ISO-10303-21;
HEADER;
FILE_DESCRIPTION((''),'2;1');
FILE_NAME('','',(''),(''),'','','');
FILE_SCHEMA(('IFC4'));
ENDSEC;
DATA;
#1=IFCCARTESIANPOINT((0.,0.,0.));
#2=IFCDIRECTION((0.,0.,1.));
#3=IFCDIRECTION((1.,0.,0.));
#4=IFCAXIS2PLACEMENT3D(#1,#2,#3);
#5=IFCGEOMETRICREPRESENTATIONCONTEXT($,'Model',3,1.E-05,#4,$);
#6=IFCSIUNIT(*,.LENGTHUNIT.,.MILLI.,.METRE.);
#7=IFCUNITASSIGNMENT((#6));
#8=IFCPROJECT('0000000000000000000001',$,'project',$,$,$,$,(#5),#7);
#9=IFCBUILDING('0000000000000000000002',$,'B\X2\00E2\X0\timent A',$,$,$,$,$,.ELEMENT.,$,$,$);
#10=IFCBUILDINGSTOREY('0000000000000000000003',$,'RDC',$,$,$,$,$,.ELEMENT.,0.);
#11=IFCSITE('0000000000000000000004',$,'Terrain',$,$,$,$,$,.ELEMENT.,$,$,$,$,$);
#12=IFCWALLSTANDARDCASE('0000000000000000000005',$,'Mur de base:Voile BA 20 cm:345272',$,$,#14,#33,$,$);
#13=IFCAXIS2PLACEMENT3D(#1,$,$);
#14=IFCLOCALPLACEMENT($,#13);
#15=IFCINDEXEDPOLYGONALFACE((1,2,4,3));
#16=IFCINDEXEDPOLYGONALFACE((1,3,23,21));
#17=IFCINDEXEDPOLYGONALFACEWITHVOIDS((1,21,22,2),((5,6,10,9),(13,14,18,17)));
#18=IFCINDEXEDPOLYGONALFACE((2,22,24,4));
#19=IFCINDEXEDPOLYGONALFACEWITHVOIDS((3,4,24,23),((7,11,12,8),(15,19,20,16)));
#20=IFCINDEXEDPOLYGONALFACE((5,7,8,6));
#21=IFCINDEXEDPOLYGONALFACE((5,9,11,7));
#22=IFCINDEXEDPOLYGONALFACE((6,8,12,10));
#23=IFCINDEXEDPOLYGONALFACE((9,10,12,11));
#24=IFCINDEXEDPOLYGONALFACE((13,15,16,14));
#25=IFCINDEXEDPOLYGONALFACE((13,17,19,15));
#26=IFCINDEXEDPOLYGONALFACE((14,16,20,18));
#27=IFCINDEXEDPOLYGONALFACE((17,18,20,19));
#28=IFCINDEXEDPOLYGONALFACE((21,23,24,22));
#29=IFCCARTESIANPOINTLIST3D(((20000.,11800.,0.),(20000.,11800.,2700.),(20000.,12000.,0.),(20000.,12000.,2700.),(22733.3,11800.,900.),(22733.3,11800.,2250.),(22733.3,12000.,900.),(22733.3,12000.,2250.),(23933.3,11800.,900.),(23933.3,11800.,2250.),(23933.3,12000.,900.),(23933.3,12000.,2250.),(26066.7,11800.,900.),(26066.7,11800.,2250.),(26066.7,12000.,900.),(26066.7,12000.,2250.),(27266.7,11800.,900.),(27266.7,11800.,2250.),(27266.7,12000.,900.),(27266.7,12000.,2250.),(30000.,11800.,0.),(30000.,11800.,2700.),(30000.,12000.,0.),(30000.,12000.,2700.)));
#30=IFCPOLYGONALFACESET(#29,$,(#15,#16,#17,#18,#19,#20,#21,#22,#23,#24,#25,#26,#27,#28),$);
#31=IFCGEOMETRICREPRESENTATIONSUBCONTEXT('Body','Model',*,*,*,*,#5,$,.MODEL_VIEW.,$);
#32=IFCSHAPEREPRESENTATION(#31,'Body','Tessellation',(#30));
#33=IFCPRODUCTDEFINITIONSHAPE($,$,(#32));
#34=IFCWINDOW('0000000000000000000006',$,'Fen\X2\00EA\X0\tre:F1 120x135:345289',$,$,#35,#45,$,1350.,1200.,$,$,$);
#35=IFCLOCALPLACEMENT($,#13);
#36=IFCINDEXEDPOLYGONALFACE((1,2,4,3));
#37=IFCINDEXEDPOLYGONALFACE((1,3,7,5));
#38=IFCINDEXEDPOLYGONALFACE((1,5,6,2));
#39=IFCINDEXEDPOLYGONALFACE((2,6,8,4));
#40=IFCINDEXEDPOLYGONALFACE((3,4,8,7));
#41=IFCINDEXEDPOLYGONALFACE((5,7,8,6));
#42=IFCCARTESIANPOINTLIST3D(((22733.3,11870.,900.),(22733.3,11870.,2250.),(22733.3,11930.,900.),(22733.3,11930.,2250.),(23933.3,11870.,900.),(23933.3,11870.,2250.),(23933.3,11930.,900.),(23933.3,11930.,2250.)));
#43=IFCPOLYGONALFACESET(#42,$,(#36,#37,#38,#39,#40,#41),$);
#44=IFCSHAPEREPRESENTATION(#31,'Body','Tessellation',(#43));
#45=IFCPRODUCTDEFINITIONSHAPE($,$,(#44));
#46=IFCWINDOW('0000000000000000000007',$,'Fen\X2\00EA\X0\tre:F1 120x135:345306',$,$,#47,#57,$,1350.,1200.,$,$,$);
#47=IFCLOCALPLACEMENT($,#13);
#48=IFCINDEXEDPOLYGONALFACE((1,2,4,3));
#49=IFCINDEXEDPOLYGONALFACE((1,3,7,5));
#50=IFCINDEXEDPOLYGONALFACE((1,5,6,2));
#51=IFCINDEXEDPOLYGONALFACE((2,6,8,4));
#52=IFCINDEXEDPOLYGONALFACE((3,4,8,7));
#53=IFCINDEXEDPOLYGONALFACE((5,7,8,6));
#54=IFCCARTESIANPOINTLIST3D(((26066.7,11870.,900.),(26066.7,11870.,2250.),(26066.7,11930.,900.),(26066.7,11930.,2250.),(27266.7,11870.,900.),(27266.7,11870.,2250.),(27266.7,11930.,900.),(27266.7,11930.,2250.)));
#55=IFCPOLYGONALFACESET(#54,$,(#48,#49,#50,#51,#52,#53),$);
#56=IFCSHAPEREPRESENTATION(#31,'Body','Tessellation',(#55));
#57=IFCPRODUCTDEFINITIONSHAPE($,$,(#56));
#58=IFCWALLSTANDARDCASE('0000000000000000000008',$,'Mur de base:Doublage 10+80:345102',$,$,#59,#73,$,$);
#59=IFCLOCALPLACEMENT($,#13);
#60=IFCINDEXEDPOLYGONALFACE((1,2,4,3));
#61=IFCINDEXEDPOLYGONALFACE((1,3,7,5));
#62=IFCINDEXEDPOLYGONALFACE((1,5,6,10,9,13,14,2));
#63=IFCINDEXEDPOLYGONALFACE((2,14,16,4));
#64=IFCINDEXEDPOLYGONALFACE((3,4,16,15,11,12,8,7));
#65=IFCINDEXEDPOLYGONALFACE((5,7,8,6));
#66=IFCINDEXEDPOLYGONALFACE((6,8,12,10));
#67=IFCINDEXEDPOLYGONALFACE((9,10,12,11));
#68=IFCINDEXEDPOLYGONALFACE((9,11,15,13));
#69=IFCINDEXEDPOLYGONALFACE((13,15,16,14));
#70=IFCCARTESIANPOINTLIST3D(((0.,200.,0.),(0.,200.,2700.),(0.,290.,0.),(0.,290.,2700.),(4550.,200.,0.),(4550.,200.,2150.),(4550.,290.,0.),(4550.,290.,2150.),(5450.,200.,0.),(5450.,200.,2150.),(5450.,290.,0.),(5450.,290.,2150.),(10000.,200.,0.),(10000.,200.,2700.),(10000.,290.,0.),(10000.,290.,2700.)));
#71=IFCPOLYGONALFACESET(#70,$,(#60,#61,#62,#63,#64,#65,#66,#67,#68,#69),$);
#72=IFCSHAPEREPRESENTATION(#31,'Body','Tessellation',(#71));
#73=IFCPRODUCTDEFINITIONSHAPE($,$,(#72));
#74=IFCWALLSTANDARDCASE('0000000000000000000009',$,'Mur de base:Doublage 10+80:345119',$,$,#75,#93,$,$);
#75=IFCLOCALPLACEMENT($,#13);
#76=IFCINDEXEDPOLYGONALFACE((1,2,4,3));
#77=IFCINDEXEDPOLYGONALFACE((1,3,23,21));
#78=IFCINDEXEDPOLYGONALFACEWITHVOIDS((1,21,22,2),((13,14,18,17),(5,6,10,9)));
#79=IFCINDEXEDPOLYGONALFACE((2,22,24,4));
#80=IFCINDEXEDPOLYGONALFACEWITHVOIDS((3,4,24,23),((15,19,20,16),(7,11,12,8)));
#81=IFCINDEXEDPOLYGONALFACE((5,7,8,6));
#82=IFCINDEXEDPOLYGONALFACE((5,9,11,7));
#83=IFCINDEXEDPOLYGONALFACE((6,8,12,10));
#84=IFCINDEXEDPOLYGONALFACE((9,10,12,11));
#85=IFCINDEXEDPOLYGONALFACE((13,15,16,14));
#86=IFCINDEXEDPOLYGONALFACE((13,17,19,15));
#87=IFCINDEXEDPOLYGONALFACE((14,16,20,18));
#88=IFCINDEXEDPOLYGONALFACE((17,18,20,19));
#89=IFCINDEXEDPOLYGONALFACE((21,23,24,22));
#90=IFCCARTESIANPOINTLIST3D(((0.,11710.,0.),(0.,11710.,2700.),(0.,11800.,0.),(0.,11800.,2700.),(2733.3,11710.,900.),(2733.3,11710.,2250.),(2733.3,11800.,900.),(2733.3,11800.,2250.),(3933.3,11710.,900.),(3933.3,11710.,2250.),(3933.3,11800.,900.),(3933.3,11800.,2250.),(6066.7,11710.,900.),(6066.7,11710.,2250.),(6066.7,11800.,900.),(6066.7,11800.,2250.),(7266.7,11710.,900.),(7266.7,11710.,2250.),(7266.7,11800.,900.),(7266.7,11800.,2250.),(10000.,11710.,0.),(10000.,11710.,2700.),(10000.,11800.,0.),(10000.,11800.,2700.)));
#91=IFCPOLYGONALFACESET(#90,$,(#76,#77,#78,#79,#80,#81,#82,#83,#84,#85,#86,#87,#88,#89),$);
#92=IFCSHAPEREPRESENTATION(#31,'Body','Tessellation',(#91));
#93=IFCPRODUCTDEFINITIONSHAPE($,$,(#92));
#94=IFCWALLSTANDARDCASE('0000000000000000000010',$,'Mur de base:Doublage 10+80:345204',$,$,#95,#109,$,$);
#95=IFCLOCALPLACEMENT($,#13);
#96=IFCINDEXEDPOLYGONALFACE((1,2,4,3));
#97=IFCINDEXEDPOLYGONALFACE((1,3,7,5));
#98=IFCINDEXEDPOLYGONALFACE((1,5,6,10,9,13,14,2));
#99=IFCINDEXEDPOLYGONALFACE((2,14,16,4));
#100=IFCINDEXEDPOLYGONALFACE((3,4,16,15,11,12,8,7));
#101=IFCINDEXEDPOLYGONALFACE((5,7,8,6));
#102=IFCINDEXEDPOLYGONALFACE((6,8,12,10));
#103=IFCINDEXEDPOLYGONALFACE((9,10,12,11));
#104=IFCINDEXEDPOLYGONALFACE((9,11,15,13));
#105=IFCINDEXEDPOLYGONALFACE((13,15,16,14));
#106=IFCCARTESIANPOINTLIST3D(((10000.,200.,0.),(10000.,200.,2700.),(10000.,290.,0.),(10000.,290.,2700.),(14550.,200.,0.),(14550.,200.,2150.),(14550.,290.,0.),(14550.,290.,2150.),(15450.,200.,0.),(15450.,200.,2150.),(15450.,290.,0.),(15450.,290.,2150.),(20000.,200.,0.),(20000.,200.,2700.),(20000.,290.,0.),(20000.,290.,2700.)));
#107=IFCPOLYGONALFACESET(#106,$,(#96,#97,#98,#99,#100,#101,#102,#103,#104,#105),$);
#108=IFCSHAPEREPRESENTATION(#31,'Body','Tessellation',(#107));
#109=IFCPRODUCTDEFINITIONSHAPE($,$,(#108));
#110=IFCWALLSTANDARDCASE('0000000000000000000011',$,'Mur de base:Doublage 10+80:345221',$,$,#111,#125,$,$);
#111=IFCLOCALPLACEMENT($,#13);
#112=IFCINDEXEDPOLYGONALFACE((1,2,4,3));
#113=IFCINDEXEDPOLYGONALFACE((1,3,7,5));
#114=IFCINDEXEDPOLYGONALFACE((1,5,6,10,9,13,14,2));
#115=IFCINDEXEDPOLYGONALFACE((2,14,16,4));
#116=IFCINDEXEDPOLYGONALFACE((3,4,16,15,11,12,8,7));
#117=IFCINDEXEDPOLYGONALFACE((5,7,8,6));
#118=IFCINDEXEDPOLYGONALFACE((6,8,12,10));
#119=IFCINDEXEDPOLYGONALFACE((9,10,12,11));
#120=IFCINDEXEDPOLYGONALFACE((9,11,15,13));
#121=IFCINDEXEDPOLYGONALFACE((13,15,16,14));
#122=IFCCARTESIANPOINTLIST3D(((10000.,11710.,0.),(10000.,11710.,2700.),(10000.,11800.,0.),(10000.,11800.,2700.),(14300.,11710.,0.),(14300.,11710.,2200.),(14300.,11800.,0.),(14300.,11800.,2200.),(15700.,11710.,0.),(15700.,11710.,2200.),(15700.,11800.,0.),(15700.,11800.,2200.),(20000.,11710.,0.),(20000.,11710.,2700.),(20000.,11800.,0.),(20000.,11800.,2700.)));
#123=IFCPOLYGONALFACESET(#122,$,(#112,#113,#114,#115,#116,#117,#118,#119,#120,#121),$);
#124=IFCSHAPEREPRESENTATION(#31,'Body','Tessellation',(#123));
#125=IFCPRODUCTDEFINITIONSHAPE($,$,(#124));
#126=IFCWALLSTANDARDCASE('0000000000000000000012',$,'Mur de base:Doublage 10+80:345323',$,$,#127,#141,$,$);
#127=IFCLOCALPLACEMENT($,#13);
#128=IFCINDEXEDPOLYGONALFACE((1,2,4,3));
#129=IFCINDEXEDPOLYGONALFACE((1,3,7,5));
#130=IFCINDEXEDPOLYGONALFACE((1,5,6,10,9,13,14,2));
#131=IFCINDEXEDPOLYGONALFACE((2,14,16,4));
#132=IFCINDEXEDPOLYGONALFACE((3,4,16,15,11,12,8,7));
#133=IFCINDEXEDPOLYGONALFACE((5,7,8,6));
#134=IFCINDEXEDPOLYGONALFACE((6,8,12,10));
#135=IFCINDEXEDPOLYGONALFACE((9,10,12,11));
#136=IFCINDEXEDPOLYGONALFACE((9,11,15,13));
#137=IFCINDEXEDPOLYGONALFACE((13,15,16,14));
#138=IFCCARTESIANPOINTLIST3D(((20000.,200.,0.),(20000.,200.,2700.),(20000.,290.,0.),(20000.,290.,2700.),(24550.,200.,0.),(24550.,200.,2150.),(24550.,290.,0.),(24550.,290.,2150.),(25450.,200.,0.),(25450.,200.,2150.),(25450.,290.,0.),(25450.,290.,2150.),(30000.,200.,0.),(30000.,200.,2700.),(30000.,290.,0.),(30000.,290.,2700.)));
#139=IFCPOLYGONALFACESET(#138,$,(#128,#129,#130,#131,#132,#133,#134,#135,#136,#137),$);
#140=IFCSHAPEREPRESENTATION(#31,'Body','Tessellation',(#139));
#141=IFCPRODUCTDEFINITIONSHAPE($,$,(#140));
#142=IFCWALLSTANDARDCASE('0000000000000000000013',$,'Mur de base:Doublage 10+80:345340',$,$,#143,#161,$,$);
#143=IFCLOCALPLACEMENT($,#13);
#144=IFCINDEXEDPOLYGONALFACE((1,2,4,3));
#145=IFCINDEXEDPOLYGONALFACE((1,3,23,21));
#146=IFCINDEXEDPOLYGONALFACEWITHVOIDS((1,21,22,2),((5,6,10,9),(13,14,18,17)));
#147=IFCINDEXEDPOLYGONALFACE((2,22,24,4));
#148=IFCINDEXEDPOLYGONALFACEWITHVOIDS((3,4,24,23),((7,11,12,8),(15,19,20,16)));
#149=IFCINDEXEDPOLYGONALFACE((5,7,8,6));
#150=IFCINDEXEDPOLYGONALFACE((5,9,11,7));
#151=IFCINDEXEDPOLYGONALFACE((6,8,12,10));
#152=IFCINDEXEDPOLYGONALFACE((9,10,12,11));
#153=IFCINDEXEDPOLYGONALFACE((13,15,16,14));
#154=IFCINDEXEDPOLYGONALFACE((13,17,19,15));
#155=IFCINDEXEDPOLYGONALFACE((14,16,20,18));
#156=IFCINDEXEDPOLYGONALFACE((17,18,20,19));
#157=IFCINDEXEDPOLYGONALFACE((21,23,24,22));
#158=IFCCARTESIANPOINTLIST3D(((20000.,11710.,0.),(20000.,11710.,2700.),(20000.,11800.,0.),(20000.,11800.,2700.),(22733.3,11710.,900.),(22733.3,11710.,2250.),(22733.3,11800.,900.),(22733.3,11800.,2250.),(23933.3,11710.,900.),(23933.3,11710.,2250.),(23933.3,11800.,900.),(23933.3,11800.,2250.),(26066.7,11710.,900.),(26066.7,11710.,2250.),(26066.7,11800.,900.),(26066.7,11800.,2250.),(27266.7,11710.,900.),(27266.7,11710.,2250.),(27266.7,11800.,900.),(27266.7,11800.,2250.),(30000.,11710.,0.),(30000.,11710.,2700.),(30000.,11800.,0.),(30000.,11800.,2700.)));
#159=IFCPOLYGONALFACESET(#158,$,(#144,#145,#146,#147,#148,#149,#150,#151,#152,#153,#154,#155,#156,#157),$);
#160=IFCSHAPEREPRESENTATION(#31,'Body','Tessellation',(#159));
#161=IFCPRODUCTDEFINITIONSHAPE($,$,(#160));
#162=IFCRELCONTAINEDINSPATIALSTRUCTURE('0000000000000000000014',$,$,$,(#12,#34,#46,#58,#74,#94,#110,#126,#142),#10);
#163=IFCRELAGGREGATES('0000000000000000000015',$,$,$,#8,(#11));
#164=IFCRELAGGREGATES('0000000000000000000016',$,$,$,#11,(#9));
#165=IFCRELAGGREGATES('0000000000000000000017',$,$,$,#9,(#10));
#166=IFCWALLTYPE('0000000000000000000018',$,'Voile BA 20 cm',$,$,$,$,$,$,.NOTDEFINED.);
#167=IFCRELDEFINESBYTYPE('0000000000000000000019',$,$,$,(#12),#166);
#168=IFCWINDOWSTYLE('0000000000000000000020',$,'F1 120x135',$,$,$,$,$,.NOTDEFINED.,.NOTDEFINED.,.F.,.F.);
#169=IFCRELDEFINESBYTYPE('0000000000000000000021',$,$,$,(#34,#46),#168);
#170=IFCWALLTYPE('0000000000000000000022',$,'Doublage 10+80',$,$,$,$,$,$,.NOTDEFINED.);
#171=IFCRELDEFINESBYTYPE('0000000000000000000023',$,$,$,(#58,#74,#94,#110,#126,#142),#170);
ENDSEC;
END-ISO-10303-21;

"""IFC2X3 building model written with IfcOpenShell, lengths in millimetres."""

from ifc_helpers import new_model, si_unit, frame, frame_2d, origin_with_axes, place, context, subcontext, project, spatial, rectangle, extrude, type_object, element, fill, save


model = new_model("IFC2X3")

# Units and contexts
model_context = context("Model", 3, precision=1e-05, world=origin_with_axes())
body_context = subcontext(model_context, "Body", "Model", "MODEL_VIEW")
ifc_project = project(units=[si_unit("LENGTHUNIT", "METRE", prefix="MILLI")], contexts=[model_context])

# Site, building, storey
site = spatial("IfcSite", under=ifc_project, Name="Terrain", CompositionType="ELEMENT")
building = spatial("IfcBuilding", under=site, Name="Bâtiment A", CompositionType="ELEMENT")
storey = spatial("IfcBuildingStorey", under=building, Name="RDC", CompositionType="ELEMENT", Elevation=0.0)

# Shared definitions
wall_type_1 = type_object("IfcWallType", Name="Voile BA 20 cm", PredefinedType="NOTDEFINED")

# Shared definitions
window_style = type_object("IfcWindowStyle", Name="F1 120x135", ConstructionType="NOTDEFINED", OperationType="NOTDEFINED", ParameterTakesPrecedence=False, Sizeable=False)

# Wall, openings, windows
wall_1_placement = place(None, origin_with_axes())
wall_1 = element("IfcWallStandardCase", 1, at=wall_1_placement, inside=storey, type_object=wall_type_1, Name="Mur de base:Voile BA 20 cm:345272", context=body_context, shape_type="SweptSolid", body=[
    extrude(rectangle(XDim=10000.0, YDim=200.0, at=frame_2d((25000.0, 11900.0))), origin_with_axes(), (0.0, 0.0, 1.0), 2700.0),
])
opening_1_placement = place(None, origin_with_axes())
opening_1 = element("IfcOpeningElement", 2, at=opening_1_placement, cuts=wall_1, context=body_context, shape_type="SweptSolid", body=[
    extrude(rectangle(XDim=1200.0, YDim=320.0, at=frame_2d((23333.3, 11900.0))), frame((0.0, 0.0, 900.0), z_axis=(0.0, 0.0, 1.0), x_axis=(1.0, 0.0, 0.0)), (0.0, 0.0, 1.0), 1350.0),
])
opening_2_placement = place(None, origin_with_axes())
opening_2 = element("IfcOpeningElement", 3, at=opening_2_placement, cuts=wall_1, context=body_context, shape_type="SweptSolid", body=[
    extrude(rectangle(XDim=1200.0, YDim=320.0, at=frame_2d((26666.7, 11900.0))), frame((0.0, 0.0, 900.0), z_axis=(0.0, 0.0, 1.0), x_axis=(1.0, 0.0, 0.0)), (0.0, 0.0, 1.0), 1350.0),
])
window_1_placement = place(None, origin_with_axes())
window_1 = element("IfcWindow", 4, at=window_1_placement, inside=storey, type_object=window_style, Name="Fenêtre:F1 120x135:345289", OverallHeight=1350.0, OverallWidth=1200.0, context=body_context, shape_type="SweptSolid", body=[
    extrude(rectangle(XDim=1200.0, YDim=60.0, at=frame_2d((23333.3, 11900.0))), frame((0.0, 0.0, 900.0), z_axis=(0.0, 0.0, 1.0), x_axis=(1.0, 0.0, 0.0)), (0.0, 0.0, 1.0), 1350.0),
])
fill(opening_1, window_1)
window_2_placement = place(None, origin_with_axes())
window_2 = element("IfcWindow", 5, at=window_2_placement, inside=storey, type_object=window_style, Name="Fenêtre:F1 120x135:345306", OverallHeight=1350.0, OverallWidth=1200.0, context=body_context, shape_type="SweptSolid", body=[
    extrude(rectangle(XDim=1200.0, YDim=60.0, at=frame_2d((26666.7, 11900.0))), frame((0.0, 0.0, 900.0), z_axis=(0.0, 0.0, 1.0), x_axis=(1.0, 0.0, 0.0)), (0.0, 0.0, 1.0), 1350.0),
])
fill(opening_2, window_2)

# Wall, opening
wall_type_2 = type_object("IfcWallType", Name="Doublage 10+80", PredefinedType="NOTDEFINED")
wall_2_placement = place(None, origin_with_axes())
wall_2 = element("IfcWallStandardCase", 6, at=wall_2_placement, inside=storey, type_object=wall_type_2, Name="Mur de base:Doublage 10+80:345102", context=body_context, shape_type="SweptSolid", body=[
    extrude(rectangle(XDim=10000.0, YDim=90.0, at=frame_2d((5000.0, 245.0))), origin_with_axes(), (0.0, 0.0, 1.0), 2700.0),
])
opening_3_placement = place(None, origin_with_axes())
element("IfcOpeningElement", 7, at=opening_3_placement, cuts=wall_2, context=body_context, shape_type="SweptSolid", body=[
    extrude(rectangle(XDim=900.0, YDim=210.0, at=frame_2d((5000.0, 245.0))), origin_with_axes(), (0.0, 0.0, 1.0), 2150.0),
])

# Wall, openings
wall_3_placement = place(None, origin_with_axes())
wall_3 = element("IfcWallStandardCase", 8, at=wall_3_placement, inside=storey, type_object=wall_type_2, Name="Mur de base:Doublage 10+80:345119", context=body_context, shape_type="SweptSolid", body=[
    extrude(rectangle(XDim=10000.0, YDim=90.0, at=frame_2d((5000.0, 11755.0))), origin_with_axes(), (0.0, 0.0, 1.0), 2700.0),
])
opening_4_placement = place(None, origin_with_axes())
element("IfcOpeningElement", 9, at=opening_4_placement, cuts=wall_3, context=body_context, shape_type="SweptSolid", body=[
    extrude(rectangle(XDim=1200.0, YDim=210.0, at=frame_2d((3333.3, 11755.0))), frame((0.0, 0.0, 900.0), z_axis=(0.0, 0.0, 1.0), x_axis=(1.0, 0.0, 0.0)), (0.0, 0.0, 1.0), 1350.0),
])
opening_5_placement = place(None, origin_with_axes())
element("IfcOpeningElement", 10, at=opening_5_placement, cuts=wall_3, context=body_context, shape_type="SweptSolid", body=[
    extrude(rectangle(XDim=1200.0, YDim=210.0, at=frame_2d((6666.7, 11755.0))), frame((0.0, 0.0, 900.0), z_axis=(0.0, 0.0, 1.0), x_axis=(1.0, 0.0, 0.0)), (0.0, 0.0, 1.0), 1350.0),
])

# Walls, openings
wall_4_placement = place(None, origin_with_axes())
wall_4 = element("IfcWallStandardCase", 11, at=wall_4_placement, inside=storey, type_object=wall_type_2, Name="Mur de base:Doublage 10+80:345204", context=body_context, shape_type="SweptSolid", body=[
    extrude(rectangle(XDim=10000.0, YDim=90.0, at=frame_2d((15000.0, 245.0))), origin_with_axes(), (0.0, 0.0, 1.0), 2700.0),
])
opening_6_placement = place(None, origin_with_axes())
element("IfcOpeningElement", 12, at=opening_6_placement, cuts=wall_4, context=body_context, shape_type="SweptSolid", body=[
    extrude(rectangle(XDim=900.0, YDim=210.0, at=frame_2d((15000.0, 245.0))), origin_with_axes(), (0.0, 0.0, 1.0), 2150.0),
])
wall_5_placement = place(None, origin_with_axes())
wall_5 = element("IfcWallStandardCase", 13, at=wall_5_placement, inside=storey, type_object=wall_type_2, Name="Mur de base:Doublage 10+80:345221", context=body_context, shape_type="SweptSolid", body=[
    extrude(rectangle(XDim=10000.0, YDim=90.0, at=frame_2d((15000.0, 11755.0))), origin_with_axes(), (0.0, 0.0, 1.0), 2700.0),
])
opening_7_placement = place(None, origin_with_axes())
element("IfcOpeningElement", 14, at=opening_7_placement, cuts=wall_5, context=body_context, shape_type="SweptSolid", body=[
    extrude(rectangle(XDim=1400.0, YDim=210.0, at=frame_2d((15000.0, 11755.0))), origin_with_axes(), (0.0, 0.0, 1.0), 2200.0),
])
wall_6_placement = place(None, origin_with_axes())
wall_6 = element("IfcWallStandardCase", 15, at=wall_6_placement, inside=storey, type_object=wall_type_2, Name="Mur de base:Doublage 10+80:345323", context=body_context, shape_type="SweptSolid", body=[
    extrude(rectangle(XDim=10000.0, YDim=90.0, at=frame_2d((25000.0, 245.0))), origin_with_axes(), (0.0, 0.0, 1.0), 2700.0),
])
opening_8_placement = place(None, origin_with_axes())
element("IfcOpeningElement", 16, at=opening_8_placement, cuts=wall_6, context=body_context, shape_type="SweptSolid", body=[
    extrude(rectangle(XDim=900.0, YDim=210.0, at=frame_2d((25000.0, 245.0))), origin_with_axes(), (0.0, 0.0, 1.0), 2150.0),
])

# Wall, openings
wall_7_placement = place(None, origin_with_axes())
wall_7 = element("IfcWallStandardCase", 17, at=wall_7_placement, inside=storey, type_object=wall_type_2, Name="Mur de base:Doublage 10+80:345340", context=body_context, shape_type="SweptSolid", body=[
    extrude(rectangle(XDim=10000.0, YDim=90.0, at=frame_2d((25000.0, 11755.0))), origin_with_axes(), (0.0, 0.0, 1.0), 2700.0),
])
opening_9_placement = place(None, origin_with_axes())
element("IfcOpeningElement", 18, at=opening_9_placement, cuts=wall_7, context=body_context, shape_type="SweptSolid", body=[
    extrude(rectangle(XDim=1200.0, YDim=210.0, at=frame_2d((23333.3, 11755.0))), frame((0.0, 0.0, 900.0), z_axis=(0.0, 0.0, 1.0), x_axis=(1.0, 0.0, 0.0)), (0.0, 0.0, 1.0), 1350.0),
])
opening_10_placement = place(None, origin_with_axes())
element("IfcOpeningElement", 19, at=opening_10_placement, cuts=wall_7, context=body_context, shape_type="SweptSolid", body=[
    extrude(rectangle(XDim=1200.0, YDim=210.0, at=frame_2d((26666.7, 11755.0))), frame((0.0, 0.0, 900.0), z_axis=(0.0, 0.0, 1.0), x_axis=(1.0, 0.0, 0.0)), (0.0, 0.0, 1.0), 1350.0),
])

save(model, "model.ifc")
